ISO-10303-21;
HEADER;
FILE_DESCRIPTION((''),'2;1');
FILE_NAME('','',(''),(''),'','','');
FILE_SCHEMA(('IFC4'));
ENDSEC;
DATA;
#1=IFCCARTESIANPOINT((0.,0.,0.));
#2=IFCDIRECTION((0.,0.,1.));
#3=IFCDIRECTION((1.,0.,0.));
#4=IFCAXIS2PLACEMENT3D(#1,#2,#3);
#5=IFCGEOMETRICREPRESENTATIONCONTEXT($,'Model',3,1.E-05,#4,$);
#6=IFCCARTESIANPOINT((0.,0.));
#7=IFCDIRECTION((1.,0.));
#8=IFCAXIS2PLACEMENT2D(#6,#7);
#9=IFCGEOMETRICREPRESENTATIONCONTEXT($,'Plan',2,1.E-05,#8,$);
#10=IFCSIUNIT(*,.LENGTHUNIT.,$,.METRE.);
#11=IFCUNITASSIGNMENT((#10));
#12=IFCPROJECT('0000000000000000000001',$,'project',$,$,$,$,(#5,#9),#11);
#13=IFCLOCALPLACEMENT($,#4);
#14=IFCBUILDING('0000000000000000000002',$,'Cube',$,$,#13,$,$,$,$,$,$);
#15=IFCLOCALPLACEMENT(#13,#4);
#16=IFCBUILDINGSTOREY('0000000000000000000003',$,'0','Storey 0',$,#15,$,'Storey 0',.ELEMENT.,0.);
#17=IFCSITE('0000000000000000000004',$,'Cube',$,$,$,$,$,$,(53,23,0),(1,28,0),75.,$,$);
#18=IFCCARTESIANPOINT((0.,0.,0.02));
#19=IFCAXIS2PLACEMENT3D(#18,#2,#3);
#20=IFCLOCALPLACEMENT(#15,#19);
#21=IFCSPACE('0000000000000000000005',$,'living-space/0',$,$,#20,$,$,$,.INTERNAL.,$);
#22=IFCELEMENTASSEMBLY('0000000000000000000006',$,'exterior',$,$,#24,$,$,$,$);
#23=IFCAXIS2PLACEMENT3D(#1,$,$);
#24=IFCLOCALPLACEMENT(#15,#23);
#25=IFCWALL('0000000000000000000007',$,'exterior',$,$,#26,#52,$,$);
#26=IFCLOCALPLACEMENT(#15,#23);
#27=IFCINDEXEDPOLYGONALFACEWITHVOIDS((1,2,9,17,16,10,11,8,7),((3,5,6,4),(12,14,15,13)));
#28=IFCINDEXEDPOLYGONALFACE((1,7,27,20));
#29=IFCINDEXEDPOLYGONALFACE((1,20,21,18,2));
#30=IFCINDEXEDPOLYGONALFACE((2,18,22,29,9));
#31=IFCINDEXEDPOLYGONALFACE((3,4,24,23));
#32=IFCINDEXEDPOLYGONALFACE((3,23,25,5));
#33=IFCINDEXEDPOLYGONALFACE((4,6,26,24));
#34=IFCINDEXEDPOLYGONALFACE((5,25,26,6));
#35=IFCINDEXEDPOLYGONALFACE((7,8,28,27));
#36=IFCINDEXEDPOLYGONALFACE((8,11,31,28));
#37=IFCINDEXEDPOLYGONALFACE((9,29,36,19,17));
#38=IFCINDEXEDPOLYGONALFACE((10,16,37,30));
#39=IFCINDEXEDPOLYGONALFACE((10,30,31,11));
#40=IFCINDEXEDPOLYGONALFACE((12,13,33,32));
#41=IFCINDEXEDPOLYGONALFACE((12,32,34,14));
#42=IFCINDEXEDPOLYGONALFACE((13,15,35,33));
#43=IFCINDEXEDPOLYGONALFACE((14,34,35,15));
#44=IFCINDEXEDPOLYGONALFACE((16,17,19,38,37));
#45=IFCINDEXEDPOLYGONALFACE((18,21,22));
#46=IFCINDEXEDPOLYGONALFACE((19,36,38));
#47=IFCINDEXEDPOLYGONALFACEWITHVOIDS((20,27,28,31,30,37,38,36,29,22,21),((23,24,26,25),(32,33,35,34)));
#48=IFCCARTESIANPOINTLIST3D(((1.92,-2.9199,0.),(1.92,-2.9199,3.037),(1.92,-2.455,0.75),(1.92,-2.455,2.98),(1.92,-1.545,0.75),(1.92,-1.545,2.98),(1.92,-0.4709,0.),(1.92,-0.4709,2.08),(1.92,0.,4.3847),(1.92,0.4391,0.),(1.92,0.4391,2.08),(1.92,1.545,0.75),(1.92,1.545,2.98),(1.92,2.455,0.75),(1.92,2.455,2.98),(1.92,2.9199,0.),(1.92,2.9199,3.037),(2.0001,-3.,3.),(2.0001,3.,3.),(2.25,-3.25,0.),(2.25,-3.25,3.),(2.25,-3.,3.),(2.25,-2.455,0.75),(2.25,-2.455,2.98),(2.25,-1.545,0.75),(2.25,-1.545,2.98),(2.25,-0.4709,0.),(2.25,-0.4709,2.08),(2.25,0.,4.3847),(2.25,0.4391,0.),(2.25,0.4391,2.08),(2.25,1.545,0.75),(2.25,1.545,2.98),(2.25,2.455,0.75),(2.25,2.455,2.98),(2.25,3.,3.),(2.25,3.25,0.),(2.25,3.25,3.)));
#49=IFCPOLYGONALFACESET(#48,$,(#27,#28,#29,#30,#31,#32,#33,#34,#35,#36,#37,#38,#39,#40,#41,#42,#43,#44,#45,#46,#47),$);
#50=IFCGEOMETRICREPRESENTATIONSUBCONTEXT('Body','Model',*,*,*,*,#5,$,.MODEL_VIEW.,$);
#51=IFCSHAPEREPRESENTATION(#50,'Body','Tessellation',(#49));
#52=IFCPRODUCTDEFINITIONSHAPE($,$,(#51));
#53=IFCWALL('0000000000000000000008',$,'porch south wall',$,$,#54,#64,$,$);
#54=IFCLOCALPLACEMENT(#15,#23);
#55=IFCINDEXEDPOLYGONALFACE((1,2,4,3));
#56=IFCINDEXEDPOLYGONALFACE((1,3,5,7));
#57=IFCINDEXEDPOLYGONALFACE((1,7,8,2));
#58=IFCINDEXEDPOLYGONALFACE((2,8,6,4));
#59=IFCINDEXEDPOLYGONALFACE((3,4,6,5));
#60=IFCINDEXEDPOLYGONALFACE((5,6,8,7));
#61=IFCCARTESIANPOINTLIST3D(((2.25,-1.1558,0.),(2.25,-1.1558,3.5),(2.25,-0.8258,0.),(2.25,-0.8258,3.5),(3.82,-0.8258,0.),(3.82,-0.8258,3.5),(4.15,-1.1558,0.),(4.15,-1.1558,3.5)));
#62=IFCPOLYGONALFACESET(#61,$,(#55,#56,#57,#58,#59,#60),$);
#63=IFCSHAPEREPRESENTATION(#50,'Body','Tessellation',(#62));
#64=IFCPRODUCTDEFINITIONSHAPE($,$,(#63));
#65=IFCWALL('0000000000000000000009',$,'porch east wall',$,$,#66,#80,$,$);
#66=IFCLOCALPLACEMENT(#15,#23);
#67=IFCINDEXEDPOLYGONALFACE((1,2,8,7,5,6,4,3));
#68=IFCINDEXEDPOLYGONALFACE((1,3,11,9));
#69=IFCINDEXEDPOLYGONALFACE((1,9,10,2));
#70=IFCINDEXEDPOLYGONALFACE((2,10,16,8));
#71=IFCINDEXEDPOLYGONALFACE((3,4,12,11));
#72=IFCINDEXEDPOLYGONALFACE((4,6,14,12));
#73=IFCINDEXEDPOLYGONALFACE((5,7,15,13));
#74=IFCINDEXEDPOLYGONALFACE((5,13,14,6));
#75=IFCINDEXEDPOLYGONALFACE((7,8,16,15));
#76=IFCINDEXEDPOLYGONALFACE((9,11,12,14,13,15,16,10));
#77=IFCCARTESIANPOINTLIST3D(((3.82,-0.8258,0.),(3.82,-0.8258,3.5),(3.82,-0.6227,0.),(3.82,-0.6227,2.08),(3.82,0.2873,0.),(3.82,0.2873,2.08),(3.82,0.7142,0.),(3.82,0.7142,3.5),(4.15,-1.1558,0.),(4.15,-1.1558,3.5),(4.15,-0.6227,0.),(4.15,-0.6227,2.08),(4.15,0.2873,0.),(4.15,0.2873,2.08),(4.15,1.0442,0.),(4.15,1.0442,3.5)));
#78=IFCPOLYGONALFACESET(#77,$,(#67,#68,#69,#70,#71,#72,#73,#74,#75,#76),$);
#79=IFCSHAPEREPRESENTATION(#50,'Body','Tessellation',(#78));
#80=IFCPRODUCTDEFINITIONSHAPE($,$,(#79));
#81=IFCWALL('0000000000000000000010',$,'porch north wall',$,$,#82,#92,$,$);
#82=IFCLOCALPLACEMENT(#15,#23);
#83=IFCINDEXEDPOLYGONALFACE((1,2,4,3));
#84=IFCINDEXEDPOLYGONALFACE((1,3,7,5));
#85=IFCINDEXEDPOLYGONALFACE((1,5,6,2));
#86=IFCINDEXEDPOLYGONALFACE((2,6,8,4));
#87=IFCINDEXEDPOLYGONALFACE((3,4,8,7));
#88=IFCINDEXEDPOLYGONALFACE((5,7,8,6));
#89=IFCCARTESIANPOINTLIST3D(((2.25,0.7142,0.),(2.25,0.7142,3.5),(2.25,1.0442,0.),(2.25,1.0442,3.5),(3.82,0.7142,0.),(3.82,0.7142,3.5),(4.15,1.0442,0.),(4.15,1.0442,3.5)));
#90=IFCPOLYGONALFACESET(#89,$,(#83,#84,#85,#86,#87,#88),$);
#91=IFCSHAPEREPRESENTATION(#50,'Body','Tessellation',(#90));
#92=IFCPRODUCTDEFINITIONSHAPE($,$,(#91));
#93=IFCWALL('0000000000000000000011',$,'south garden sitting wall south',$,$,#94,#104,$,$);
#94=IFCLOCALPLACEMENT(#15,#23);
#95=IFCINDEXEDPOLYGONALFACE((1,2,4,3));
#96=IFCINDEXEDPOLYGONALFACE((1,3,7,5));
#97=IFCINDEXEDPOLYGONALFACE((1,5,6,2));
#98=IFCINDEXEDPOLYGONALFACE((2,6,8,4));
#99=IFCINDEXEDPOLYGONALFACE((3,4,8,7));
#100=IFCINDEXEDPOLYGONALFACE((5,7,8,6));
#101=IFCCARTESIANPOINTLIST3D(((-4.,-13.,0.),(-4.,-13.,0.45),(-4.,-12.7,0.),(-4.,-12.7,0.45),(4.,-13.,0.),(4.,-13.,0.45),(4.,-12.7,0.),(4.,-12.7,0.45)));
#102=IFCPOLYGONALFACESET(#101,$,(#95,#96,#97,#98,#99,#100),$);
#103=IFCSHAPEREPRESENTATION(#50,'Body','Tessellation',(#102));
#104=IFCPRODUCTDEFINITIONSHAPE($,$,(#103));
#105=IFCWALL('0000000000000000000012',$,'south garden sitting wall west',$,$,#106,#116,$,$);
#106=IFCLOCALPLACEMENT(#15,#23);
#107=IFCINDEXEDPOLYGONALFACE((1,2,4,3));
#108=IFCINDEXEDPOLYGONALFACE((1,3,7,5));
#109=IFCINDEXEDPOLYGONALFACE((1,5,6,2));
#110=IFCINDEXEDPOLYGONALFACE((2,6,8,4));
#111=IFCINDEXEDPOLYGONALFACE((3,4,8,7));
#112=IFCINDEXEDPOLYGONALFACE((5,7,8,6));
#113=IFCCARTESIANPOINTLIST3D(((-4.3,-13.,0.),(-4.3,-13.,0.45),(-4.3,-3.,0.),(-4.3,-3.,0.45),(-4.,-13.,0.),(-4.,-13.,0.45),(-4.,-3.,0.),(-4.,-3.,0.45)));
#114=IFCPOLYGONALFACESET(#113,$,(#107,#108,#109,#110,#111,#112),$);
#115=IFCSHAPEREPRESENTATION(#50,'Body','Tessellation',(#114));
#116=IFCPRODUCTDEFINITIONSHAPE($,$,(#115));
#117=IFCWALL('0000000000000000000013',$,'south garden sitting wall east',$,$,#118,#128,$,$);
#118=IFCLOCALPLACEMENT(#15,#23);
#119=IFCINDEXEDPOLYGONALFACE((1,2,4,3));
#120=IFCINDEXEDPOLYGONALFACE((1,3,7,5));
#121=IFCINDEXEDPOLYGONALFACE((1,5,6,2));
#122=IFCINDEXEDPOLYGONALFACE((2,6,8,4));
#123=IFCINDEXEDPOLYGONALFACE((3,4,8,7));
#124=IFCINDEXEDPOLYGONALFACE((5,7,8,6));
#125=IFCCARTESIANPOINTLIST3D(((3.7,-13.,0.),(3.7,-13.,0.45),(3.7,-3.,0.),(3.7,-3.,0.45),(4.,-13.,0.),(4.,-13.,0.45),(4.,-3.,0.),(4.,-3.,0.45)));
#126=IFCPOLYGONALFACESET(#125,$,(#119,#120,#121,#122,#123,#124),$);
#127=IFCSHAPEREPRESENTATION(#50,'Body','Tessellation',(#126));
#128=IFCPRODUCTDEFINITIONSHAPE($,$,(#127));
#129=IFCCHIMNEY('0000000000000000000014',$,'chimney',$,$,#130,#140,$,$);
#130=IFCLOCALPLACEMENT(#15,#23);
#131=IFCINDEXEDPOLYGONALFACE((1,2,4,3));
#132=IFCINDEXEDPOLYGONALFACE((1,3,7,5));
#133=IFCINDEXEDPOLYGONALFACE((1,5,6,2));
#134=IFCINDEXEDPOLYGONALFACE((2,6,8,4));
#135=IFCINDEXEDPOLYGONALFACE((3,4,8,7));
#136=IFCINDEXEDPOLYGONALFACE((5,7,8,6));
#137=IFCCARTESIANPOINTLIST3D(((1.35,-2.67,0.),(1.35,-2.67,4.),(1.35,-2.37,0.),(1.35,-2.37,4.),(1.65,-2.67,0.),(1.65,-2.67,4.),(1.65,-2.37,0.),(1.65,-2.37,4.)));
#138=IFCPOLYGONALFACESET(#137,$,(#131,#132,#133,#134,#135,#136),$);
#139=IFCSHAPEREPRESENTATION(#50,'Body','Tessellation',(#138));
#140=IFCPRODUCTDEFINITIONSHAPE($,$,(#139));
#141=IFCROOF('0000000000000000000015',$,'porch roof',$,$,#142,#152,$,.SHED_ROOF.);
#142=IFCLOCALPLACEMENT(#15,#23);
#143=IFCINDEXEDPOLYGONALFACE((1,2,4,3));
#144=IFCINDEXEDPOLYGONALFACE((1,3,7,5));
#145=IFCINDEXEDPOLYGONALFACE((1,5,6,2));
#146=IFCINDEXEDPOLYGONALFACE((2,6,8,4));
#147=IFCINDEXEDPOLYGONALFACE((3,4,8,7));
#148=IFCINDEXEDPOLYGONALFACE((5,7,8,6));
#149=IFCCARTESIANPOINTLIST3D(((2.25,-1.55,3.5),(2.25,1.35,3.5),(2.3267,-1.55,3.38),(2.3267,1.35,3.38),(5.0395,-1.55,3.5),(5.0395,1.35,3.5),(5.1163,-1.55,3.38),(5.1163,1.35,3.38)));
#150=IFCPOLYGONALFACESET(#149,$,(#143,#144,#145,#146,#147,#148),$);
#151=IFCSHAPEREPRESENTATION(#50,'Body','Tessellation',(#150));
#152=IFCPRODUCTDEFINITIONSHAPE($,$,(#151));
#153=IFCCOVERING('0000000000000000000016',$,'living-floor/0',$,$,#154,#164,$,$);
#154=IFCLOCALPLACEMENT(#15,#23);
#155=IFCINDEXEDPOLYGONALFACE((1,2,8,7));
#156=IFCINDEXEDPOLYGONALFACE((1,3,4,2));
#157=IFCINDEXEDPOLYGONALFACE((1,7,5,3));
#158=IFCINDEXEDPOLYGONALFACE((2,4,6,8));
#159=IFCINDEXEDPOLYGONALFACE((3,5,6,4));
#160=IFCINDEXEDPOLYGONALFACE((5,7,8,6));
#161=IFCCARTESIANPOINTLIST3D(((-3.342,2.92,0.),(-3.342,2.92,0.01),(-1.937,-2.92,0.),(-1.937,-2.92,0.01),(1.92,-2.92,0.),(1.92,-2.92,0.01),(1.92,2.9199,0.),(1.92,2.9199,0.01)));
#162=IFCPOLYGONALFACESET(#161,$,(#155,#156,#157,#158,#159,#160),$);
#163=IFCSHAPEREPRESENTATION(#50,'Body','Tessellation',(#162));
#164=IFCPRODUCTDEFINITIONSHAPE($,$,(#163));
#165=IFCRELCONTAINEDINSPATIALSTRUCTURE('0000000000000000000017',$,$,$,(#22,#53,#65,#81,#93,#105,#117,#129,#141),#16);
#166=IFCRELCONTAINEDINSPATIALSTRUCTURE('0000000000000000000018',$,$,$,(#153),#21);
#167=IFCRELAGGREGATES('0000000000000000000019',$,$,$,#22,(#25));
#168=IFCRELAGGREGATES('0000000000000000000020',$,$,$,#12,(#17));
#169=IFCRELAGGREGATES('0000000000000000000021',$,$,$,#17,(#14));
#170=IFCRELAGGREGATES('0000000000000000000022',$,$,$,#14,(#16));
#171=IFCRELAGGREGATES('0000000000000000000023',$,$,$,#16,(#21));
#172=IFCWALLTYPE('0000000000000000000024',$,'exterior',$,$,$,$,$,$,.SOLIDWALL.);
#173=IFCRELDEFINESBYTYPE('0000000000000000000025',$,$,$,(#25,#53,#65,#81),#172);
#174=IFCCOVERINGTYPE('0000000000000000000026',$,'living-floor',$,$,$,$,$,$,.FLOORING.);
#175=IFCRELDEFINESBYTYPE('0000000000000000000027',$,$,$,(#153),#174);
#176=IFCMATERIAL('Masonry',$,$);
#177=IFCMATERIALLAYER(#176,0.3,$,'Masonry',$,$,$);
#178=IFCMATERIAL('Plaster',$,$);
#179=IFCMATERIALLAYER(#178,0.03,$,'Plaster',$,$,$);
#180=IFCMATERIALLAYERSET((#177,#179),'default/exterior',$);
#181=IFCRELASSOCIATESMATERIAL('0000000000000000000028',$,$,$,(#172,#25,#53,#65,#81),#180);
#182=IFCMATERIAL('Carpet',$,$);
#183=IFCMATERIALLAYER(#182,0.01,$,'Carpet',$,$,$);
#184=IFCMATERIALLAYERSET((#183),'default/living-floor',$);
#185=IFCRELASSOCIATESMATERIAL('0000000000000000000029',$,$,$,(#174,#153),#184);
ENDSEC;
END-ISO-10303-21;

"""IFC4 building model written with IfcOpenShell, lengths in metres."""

from ifc_helpers import new_model, si_unit, frame, origin, origin_with_axes, origin_2d_with_axis, place, context, subcontext, project, spatial, polyline, line, indexed_curve, outline, extrude, clip, bounded_halfspace, source, transform, mapped, material, layer, layer_set, layer_usage, type_object, element, aggregate, save


model = new_model("IFC4")

# Units and contexts
model_context = context("Model", 3, precision=1e-05, world=origin_with_axes())
plan_context = context("Plan", 2, precision=1e-05, world=origin_2d_with_axis())
body_context = subcontext(model_context, "Body", "Model", "MODEL_VIEW")
ifc_project = project(units=[si_unit("LENGTHUNIT", "METRE")], contexts=[model_context, plan_context])

# Site, building, storey
site = spatial("IfcSite", under=ifc_project, Name="Cube", RefLatitude=(53, 23, 0), RefLongitude=(1, 28, 0), RefElevation=75.0)
building_placement = place(None, origin_with_axes())
building = spatial("IfcBuilding", under=site, at=building_placement, Name="Cube")
storey_placement = place(building_placement, origin_with_axes())
storey = spatial("IfcBuildingStorey", under=building, at=storey_placement, Name="0", Description="Storey 0", LongName="Storey 0", CompositionType="ELEMENT", Elevation=0.0)

# Element assembly, wall, openings
ifc_material_1 = material(Name="Masonry")
ifc_layer_1 = layer(ifc_material_1, 0.3, Name="Masonry")
ifc_material_2 = material(Name="Plaster")
ifc_layer_2 = layer(ifc_material_2, 0.03, Name="Plaster")
ifc_layer_set_1 = layer_set([ifc_layer_1, ifc_layer_2], Name="default/exterior")
wall_type = type_object("IfcWallType", Name="exterior", PredefinedType="SOLIDWALL", material=ifc_layer_set_1)
assembly_1_placement = place(storey_placement, frame((2.0, -3.0, 0.0), z_axis=(0.0, 0.0, 1.0), x_axis=(0.0, 1.0, 0.0)))
assembly_1 = element("IfcElementAssembly", 1, at=assembly_1_placement, inside=storey, Name="exterior")
ifc_layer_usage_1 = layer_usage(ifc_layer_set_1, "AXIS2", "POSITIVE", -0.25)
wall_1_placement = place(assembly_1_placement, origin_with_axes())
wall_1 = element("IfcWall", 2, at=wall_1_placement, type_object=wall_type, material=ifc_layer_usage_1, Name="exterior", context=body_context, shape_type="Clipping", body=[
    clip(clip(clip(clip(extrude(outline(polyline([(0.0801, 0.08), (-0.25, -0.25), (6.25, -0.25), (5.9199, 0.08), (0.0801, 0.08)])), origin(), (0.0, 0.0, 1.0), 4.385), bounded_halfspace(frame((6.0, 0.0, 3.0), z_axis=(0.419069, 0.0, 0.907954), x_axis=(0.0, -1.0, 0.0)), False, origin(), polyline([(6.0, -1.0), (3.0, -1.0), (3.0, 1.0), (6.0, 1.0), (6.0, -1.0)]))), bounded_halfspace(frame((6.0, 0.0, 3.0), z_axis=(0.0, 0.0, 1.0), x_axis=(0.0, 1.0, 0.0)), False, origin(), polyline([(6.0, 1.0), (7.0, 1.0), (7.0, -1.0), (6.0, -1.0), (6.0, 1.0)]))), bounded_halfspace(frame((3.0, 0.0, 4.3847), z_axis=(-0.419069, 0.0, 0.907954), x_axis=(0.0, -1.0, 0.0)), False, origin(), polyline([(3.0, -1.0), (0.0, -1.0), (0.0, 1.0), (3.0, 1.0), (3.0, -1.0)]))), bounded_halfspace(frame((0.0, 0.0, 3.0), z_axis=(0.0, 0.0, 1.0), x_axis=(0.0, -1.0, 0.0)), False, origin(), polyline([(0.0, -1.0), (-1.0, -1.0), (-1.0, 1.0), (0.0, 1.0), (0.0, -1.0)]))),
])
opening_1_placement = place(wall_1_placement, frame((0.545, -0.25, 0.75), z_axis=(0.0, 0.0, 1.0), x_axis=(1.0, 0.0, 0.0)))
element("IfcOpeningElement", 3, at=opening_1_placement, cuts=wall_1, PredefinedType="OPENING", context=body_context, shape_type="SweptSolid", body=[
    extrude(outline(polyline([(0.0, -0.02), (0.91, -0.02), (0.91, 0.35), (0.0, 0.35), (0.0, -0.02)])), origin(), (0.0, 0.0, 1.0), 2.23),
])
opening_2_placement = place(wall_1_placement, frame((4.545, -0.25, 0.75), z_axis=(0.0, 0.0, 1.0), x_axis=(1.0, 0.0, 0.0)))
element("IfcOpeningElement", 4, at=opening_2_placement, cuts=wall_1, PredefinedType="OPENING", context=body_context, shape_type="SweptSolid", body=[
    extrude(outline(polyline([(0.0, -0.02), (0.91, -0.02), (0.91, 0.35), (0.0, 0.35), (0.0, -0.02)])), origin(), (0.0, 0.0, 1.0), 2.23),
])
shared_shape_1 = source(origin_with_axes(), body_context, "Body", "SweptSolid", [
    extrude(outline(indexed_curve([(0.0, 0.0), (0.91, 0.0), (0.91, 2.08), (0.0, 2.08)], segments=[line(1, 2, 3, 4, 1)])), frame((0.0, -0.6, 0.0), z_axis=(0.0, -1.0, 0.0), x_axis=(1.0, 0.0, 0.0)), (0.0, 0.0, -1.0), 1.2),
])
opening_3_placement = place(wall_1_placement, frame((2.5291, -0.25, 0.0), z_axis=(0.0, 0.0, 1.0), x_axis=(1.0, 0.0, 0.0)))
element("IfcOpeningElement", 5, at=opening_3_placement, cuts=wall_1, PredefinedType="OPENING", context=body_context, shape_type="MappedRepresentation", body=[
    mapped(shared_shape_1, transform((0.0, 0.0, 0.0), x_axis=(1.0, 0.0, 0.0), y_axis=(0.0, 1.0, 0.0), z_axis=(0.0, 0.0, 1.0), scale=1.0)),
])
aggregate(assembly_1, [wall_1])

# Wall
ifc_layer_usage_2 = layer_usage(ifc_layer_set_1, "AXIS2", "POSITIVE", 0.0)
wall_2_placement = place(storey_placement, frame((2.25, -1.1558, 0.0), z_axis=(0.0, 0.0, 1.0), x_axis=(1.0, 0.0, 0.0)))
element("IfcWall", 6, at=wall_2_placement, inside=storey, type_object=wall_type, material=ifc_layer_usage_2, Name="porch south wall", context=body_context, shape_type="SweptSolid", body=[
    extrude(outline(indexed_curve([(0.0, 0.0), (0.0, 0.33), (1.57, 0.33), (1.9, 0.0)], segments=[line(1, 2, 3, 4, 1)])), origin_with_axes(), (0.0, 0.0, 1.0), 3.5),
])

# Wall, opening
ifc_layer_usage_3 = layer_usage(ifc_layer_set_1, "AXIS2", "POSITIVE", 0.0)
wall_3_placement = place(storey_placement, frame((4.15, -1.1558, 0.0), z_axis=(0.0, 0.0, 1.0), x_axis=(0.0, 1.0, 0.0)))
wall_3 = element("IfcWall", 7, at=wall_3_placement, inside=storey, type_object=wall_type, material=ifc_layer_usage_3, Name="porch east wall", context=body_context, shape_type="SweptSolid", body=[
    extrude(outline(indexed_curve([(0.0, 0.0), (0.33, 0.33), (1.87, 0.33), (2.2, 0.0)], segments=[line(1, 2, 3, 4, 1)])), origin_with_axes(), (0.0, 0.0, 1.0), 3.5),
])
shared_shape_2 = source(origin_with_axes(), body_context, "Body", "SweptSolid", [
    extrude(outline(indexed_curve([(0.0, 0.0), (0.91, 0.0), (0.91, 2.08), (0.0, 2.08)], segments=[line(1, 2, 3, 4, 1)])), frame((0.0, -0.6, 0.0), z_axis=(0.0, -1.0, 0.0), x_axis=(1.0, 0.0, 0.0)), (0.0, 0.0, -1.0), 1.2),
])
opening_4_placement = place(wall_3_placement, frame((0.5331, 0.0, 0.0), z_axis=(0.0, 0.0, 1.0), x_axis=(1.0, 0.0, 0.0)))
element("IfcOpeningElement", 8, at=opening_4_placement, cuts=wall_3, PredefinedType="OPENING", context=body_context, shape_type="MappedRepresentation", body=[
    mapped(shared_shape_2, transform((0.0, 0.0, 0.0), x_axis=(1.0, 0.0, 0.0), y_axis=(0.0, 1.0, 0.0), z_axis=(0.0, 0.0, 1.0), scale=1.0)),
])

# Walls
ifc_layer_usage_4 = layer_usage(ifc_layer_set_1, "AXIS2", "POSITIVE", 0.0)
wall_4_placement = place(storey_placement, frame((4.15, 1.0442, 0.0), z_axis=(0.0, 0.0, 1.0), x_axis=(-1.0, 0.0, 0.0)))
element("IfcWall", 9, at=wall_4_placement, inside=storey, type_object=wall_type, material=ifc_layer_usage_4, Name="porch north wall", context=body_context, shape_type="SweptSolid", body=[
    extrude(outline(indexed_curve([(0.0, 0.0), (0.33, 0.33), (1.9, 0.33), (1.9, 0.0)], segments=[line(1, 2, 3, 4, 1)])), origin_with_axes(), (0.0, 0.0, 1.0), 3.5),
])
wall_5_placement = place(storey_placement, frame((-4.0, -13.0, 0.0), z_axis=(0.0, 0.0, 1.0), x_axis=(1.0, 0.0, 0.0)))
element("IfcWall", 10, at=wall_5_placement, inside=storey, Name="south garden sitting wall south", context=body_context, shape_type="SweptSolid", body=[
    extrude(outline(indexed_curve([(0.0, 0.0), (0.0, 0.3), (8.0, 0.3), (8.0, 0.0), (0.0, 0.0)], self_intersect=False)), origin_with_axes(), (0.0, 0.0, 1.0), 0.45),
])
for number, where, z_axis, x_axis, name in (
    (11, (-4.0, -13.0, 0.0), (0.0, 0.0, 1.0), (0.0, 1.0, 0.0), "south garden sitting wall west"),
    (12, (4.0, -13.0, 0.0), (0.0, 0.0, 1.0), (0.0, 1.0, 0.0), "south garden sitting wall east"),
):
    element("IfcWall", number, at=place(storey_placement, frame(where, z_axis=z_axis, x_axis=x_axis)), inside=storey, Name=name, context=body_context, shape_type="SweptSolid", body=[
        extrude(outline(indexed_curve([(0.0, 0.0), (0.0, 0.3), (10.0, 0.3), (10.0, 0.0), (0.0, 0.0)], self_intersect=False)), origin_with_axes(), (0.0, 0.0, 1.0), 0.45),
    ])

# Chimney
chimney_placement = place(storey_placement, frame((1.35, -2.67, 0.0), z_axis=(0.0, 0.0, 1.0), x_axis=(1.0, 0.0, 0.0)))
element("IfcChimney", 13, at=chimney_placement, inside=storey, Name="chimney", context=body_context, shape_type="SweptSolid", body=[
    extrude(outline(indexed_curve([(0.0, 0.0), (0.3, 0.0), (0.3, 0.3), (0.0, 0.3)])), None, (0.0, 0.0, 1.0), 4.0),
])

# Roof
roof_placement = place(storey_placement, frame((2.25, 1.35, 3.5), z_axis=(0.0, 0.0, 1.0), x_axis=(0.0, -1.0, 0.0)))
element("IfcRoof", 14, at=roof_placement, inside=storey, Name="porch roof", PredefinedType="SHED_ROOF", context=body_context, shape_type="SweptSolid", body=[
    extrude(outline(indexed_curve([(0.0, 0.0), (2.9, 0.0), (2.9, 2.7895), (0.0, 2.7895)])), None, (0.0, 0.53879, -0.84244), 0.1424),
])

# Shared definitions
space_placement = place(storey_placement, frame((0.0, 0.0, 0.02), z_axis=(0.0, 0.0, 1.0), x_axis=(1.0, 0.0, 0.0)))
space = spatial("IfcSpace", under=storey, at=space_placement, Name="living-space/0", PredefinedType="INTERNAL")

# Covering
ifc_material_3 = material(Name="Carpet")
ifc_layer_3 = layer(ifc_material_3, 0.01, Name="Carpet")
ifc_layer_set_2 = layer_set([ifc_layer_3], Name="default/living-floor")
ifc_layer_usage_5 = layer_usage(ifc_layer_set_2, "AXIS3", "POSITIVE", 0.0)
covering_type = type_object("IfcCoveringType", Name="living-floor", PredefinedType="FLOORING", material=ifc_layer_set_2)
covering_1_placement = place(space_placement, frame((0.0, 0.0, -0.02), z_axis=(0.0, 0.0, 1.0), x_axis=(1.0, 0.0, 0.0)))
element("IfcCovering", 15, at=covering_1_placement, inside=space, type_object=covering_type, material=ifc_layer_usage_5, Name="living-floor/0", context=body_context, shape_type="SweptSolid", body=[
    extrude(outline(polyline([(1.92, 2.9199), (-3.342, 2.92), (-1.937, -2.92), (1.92, -2.92), (1.92, 2.9199)])), origin_with_axes(), (0.0, 0.0, 1.0), 0.01),
])

save(model, "model.ifc")
